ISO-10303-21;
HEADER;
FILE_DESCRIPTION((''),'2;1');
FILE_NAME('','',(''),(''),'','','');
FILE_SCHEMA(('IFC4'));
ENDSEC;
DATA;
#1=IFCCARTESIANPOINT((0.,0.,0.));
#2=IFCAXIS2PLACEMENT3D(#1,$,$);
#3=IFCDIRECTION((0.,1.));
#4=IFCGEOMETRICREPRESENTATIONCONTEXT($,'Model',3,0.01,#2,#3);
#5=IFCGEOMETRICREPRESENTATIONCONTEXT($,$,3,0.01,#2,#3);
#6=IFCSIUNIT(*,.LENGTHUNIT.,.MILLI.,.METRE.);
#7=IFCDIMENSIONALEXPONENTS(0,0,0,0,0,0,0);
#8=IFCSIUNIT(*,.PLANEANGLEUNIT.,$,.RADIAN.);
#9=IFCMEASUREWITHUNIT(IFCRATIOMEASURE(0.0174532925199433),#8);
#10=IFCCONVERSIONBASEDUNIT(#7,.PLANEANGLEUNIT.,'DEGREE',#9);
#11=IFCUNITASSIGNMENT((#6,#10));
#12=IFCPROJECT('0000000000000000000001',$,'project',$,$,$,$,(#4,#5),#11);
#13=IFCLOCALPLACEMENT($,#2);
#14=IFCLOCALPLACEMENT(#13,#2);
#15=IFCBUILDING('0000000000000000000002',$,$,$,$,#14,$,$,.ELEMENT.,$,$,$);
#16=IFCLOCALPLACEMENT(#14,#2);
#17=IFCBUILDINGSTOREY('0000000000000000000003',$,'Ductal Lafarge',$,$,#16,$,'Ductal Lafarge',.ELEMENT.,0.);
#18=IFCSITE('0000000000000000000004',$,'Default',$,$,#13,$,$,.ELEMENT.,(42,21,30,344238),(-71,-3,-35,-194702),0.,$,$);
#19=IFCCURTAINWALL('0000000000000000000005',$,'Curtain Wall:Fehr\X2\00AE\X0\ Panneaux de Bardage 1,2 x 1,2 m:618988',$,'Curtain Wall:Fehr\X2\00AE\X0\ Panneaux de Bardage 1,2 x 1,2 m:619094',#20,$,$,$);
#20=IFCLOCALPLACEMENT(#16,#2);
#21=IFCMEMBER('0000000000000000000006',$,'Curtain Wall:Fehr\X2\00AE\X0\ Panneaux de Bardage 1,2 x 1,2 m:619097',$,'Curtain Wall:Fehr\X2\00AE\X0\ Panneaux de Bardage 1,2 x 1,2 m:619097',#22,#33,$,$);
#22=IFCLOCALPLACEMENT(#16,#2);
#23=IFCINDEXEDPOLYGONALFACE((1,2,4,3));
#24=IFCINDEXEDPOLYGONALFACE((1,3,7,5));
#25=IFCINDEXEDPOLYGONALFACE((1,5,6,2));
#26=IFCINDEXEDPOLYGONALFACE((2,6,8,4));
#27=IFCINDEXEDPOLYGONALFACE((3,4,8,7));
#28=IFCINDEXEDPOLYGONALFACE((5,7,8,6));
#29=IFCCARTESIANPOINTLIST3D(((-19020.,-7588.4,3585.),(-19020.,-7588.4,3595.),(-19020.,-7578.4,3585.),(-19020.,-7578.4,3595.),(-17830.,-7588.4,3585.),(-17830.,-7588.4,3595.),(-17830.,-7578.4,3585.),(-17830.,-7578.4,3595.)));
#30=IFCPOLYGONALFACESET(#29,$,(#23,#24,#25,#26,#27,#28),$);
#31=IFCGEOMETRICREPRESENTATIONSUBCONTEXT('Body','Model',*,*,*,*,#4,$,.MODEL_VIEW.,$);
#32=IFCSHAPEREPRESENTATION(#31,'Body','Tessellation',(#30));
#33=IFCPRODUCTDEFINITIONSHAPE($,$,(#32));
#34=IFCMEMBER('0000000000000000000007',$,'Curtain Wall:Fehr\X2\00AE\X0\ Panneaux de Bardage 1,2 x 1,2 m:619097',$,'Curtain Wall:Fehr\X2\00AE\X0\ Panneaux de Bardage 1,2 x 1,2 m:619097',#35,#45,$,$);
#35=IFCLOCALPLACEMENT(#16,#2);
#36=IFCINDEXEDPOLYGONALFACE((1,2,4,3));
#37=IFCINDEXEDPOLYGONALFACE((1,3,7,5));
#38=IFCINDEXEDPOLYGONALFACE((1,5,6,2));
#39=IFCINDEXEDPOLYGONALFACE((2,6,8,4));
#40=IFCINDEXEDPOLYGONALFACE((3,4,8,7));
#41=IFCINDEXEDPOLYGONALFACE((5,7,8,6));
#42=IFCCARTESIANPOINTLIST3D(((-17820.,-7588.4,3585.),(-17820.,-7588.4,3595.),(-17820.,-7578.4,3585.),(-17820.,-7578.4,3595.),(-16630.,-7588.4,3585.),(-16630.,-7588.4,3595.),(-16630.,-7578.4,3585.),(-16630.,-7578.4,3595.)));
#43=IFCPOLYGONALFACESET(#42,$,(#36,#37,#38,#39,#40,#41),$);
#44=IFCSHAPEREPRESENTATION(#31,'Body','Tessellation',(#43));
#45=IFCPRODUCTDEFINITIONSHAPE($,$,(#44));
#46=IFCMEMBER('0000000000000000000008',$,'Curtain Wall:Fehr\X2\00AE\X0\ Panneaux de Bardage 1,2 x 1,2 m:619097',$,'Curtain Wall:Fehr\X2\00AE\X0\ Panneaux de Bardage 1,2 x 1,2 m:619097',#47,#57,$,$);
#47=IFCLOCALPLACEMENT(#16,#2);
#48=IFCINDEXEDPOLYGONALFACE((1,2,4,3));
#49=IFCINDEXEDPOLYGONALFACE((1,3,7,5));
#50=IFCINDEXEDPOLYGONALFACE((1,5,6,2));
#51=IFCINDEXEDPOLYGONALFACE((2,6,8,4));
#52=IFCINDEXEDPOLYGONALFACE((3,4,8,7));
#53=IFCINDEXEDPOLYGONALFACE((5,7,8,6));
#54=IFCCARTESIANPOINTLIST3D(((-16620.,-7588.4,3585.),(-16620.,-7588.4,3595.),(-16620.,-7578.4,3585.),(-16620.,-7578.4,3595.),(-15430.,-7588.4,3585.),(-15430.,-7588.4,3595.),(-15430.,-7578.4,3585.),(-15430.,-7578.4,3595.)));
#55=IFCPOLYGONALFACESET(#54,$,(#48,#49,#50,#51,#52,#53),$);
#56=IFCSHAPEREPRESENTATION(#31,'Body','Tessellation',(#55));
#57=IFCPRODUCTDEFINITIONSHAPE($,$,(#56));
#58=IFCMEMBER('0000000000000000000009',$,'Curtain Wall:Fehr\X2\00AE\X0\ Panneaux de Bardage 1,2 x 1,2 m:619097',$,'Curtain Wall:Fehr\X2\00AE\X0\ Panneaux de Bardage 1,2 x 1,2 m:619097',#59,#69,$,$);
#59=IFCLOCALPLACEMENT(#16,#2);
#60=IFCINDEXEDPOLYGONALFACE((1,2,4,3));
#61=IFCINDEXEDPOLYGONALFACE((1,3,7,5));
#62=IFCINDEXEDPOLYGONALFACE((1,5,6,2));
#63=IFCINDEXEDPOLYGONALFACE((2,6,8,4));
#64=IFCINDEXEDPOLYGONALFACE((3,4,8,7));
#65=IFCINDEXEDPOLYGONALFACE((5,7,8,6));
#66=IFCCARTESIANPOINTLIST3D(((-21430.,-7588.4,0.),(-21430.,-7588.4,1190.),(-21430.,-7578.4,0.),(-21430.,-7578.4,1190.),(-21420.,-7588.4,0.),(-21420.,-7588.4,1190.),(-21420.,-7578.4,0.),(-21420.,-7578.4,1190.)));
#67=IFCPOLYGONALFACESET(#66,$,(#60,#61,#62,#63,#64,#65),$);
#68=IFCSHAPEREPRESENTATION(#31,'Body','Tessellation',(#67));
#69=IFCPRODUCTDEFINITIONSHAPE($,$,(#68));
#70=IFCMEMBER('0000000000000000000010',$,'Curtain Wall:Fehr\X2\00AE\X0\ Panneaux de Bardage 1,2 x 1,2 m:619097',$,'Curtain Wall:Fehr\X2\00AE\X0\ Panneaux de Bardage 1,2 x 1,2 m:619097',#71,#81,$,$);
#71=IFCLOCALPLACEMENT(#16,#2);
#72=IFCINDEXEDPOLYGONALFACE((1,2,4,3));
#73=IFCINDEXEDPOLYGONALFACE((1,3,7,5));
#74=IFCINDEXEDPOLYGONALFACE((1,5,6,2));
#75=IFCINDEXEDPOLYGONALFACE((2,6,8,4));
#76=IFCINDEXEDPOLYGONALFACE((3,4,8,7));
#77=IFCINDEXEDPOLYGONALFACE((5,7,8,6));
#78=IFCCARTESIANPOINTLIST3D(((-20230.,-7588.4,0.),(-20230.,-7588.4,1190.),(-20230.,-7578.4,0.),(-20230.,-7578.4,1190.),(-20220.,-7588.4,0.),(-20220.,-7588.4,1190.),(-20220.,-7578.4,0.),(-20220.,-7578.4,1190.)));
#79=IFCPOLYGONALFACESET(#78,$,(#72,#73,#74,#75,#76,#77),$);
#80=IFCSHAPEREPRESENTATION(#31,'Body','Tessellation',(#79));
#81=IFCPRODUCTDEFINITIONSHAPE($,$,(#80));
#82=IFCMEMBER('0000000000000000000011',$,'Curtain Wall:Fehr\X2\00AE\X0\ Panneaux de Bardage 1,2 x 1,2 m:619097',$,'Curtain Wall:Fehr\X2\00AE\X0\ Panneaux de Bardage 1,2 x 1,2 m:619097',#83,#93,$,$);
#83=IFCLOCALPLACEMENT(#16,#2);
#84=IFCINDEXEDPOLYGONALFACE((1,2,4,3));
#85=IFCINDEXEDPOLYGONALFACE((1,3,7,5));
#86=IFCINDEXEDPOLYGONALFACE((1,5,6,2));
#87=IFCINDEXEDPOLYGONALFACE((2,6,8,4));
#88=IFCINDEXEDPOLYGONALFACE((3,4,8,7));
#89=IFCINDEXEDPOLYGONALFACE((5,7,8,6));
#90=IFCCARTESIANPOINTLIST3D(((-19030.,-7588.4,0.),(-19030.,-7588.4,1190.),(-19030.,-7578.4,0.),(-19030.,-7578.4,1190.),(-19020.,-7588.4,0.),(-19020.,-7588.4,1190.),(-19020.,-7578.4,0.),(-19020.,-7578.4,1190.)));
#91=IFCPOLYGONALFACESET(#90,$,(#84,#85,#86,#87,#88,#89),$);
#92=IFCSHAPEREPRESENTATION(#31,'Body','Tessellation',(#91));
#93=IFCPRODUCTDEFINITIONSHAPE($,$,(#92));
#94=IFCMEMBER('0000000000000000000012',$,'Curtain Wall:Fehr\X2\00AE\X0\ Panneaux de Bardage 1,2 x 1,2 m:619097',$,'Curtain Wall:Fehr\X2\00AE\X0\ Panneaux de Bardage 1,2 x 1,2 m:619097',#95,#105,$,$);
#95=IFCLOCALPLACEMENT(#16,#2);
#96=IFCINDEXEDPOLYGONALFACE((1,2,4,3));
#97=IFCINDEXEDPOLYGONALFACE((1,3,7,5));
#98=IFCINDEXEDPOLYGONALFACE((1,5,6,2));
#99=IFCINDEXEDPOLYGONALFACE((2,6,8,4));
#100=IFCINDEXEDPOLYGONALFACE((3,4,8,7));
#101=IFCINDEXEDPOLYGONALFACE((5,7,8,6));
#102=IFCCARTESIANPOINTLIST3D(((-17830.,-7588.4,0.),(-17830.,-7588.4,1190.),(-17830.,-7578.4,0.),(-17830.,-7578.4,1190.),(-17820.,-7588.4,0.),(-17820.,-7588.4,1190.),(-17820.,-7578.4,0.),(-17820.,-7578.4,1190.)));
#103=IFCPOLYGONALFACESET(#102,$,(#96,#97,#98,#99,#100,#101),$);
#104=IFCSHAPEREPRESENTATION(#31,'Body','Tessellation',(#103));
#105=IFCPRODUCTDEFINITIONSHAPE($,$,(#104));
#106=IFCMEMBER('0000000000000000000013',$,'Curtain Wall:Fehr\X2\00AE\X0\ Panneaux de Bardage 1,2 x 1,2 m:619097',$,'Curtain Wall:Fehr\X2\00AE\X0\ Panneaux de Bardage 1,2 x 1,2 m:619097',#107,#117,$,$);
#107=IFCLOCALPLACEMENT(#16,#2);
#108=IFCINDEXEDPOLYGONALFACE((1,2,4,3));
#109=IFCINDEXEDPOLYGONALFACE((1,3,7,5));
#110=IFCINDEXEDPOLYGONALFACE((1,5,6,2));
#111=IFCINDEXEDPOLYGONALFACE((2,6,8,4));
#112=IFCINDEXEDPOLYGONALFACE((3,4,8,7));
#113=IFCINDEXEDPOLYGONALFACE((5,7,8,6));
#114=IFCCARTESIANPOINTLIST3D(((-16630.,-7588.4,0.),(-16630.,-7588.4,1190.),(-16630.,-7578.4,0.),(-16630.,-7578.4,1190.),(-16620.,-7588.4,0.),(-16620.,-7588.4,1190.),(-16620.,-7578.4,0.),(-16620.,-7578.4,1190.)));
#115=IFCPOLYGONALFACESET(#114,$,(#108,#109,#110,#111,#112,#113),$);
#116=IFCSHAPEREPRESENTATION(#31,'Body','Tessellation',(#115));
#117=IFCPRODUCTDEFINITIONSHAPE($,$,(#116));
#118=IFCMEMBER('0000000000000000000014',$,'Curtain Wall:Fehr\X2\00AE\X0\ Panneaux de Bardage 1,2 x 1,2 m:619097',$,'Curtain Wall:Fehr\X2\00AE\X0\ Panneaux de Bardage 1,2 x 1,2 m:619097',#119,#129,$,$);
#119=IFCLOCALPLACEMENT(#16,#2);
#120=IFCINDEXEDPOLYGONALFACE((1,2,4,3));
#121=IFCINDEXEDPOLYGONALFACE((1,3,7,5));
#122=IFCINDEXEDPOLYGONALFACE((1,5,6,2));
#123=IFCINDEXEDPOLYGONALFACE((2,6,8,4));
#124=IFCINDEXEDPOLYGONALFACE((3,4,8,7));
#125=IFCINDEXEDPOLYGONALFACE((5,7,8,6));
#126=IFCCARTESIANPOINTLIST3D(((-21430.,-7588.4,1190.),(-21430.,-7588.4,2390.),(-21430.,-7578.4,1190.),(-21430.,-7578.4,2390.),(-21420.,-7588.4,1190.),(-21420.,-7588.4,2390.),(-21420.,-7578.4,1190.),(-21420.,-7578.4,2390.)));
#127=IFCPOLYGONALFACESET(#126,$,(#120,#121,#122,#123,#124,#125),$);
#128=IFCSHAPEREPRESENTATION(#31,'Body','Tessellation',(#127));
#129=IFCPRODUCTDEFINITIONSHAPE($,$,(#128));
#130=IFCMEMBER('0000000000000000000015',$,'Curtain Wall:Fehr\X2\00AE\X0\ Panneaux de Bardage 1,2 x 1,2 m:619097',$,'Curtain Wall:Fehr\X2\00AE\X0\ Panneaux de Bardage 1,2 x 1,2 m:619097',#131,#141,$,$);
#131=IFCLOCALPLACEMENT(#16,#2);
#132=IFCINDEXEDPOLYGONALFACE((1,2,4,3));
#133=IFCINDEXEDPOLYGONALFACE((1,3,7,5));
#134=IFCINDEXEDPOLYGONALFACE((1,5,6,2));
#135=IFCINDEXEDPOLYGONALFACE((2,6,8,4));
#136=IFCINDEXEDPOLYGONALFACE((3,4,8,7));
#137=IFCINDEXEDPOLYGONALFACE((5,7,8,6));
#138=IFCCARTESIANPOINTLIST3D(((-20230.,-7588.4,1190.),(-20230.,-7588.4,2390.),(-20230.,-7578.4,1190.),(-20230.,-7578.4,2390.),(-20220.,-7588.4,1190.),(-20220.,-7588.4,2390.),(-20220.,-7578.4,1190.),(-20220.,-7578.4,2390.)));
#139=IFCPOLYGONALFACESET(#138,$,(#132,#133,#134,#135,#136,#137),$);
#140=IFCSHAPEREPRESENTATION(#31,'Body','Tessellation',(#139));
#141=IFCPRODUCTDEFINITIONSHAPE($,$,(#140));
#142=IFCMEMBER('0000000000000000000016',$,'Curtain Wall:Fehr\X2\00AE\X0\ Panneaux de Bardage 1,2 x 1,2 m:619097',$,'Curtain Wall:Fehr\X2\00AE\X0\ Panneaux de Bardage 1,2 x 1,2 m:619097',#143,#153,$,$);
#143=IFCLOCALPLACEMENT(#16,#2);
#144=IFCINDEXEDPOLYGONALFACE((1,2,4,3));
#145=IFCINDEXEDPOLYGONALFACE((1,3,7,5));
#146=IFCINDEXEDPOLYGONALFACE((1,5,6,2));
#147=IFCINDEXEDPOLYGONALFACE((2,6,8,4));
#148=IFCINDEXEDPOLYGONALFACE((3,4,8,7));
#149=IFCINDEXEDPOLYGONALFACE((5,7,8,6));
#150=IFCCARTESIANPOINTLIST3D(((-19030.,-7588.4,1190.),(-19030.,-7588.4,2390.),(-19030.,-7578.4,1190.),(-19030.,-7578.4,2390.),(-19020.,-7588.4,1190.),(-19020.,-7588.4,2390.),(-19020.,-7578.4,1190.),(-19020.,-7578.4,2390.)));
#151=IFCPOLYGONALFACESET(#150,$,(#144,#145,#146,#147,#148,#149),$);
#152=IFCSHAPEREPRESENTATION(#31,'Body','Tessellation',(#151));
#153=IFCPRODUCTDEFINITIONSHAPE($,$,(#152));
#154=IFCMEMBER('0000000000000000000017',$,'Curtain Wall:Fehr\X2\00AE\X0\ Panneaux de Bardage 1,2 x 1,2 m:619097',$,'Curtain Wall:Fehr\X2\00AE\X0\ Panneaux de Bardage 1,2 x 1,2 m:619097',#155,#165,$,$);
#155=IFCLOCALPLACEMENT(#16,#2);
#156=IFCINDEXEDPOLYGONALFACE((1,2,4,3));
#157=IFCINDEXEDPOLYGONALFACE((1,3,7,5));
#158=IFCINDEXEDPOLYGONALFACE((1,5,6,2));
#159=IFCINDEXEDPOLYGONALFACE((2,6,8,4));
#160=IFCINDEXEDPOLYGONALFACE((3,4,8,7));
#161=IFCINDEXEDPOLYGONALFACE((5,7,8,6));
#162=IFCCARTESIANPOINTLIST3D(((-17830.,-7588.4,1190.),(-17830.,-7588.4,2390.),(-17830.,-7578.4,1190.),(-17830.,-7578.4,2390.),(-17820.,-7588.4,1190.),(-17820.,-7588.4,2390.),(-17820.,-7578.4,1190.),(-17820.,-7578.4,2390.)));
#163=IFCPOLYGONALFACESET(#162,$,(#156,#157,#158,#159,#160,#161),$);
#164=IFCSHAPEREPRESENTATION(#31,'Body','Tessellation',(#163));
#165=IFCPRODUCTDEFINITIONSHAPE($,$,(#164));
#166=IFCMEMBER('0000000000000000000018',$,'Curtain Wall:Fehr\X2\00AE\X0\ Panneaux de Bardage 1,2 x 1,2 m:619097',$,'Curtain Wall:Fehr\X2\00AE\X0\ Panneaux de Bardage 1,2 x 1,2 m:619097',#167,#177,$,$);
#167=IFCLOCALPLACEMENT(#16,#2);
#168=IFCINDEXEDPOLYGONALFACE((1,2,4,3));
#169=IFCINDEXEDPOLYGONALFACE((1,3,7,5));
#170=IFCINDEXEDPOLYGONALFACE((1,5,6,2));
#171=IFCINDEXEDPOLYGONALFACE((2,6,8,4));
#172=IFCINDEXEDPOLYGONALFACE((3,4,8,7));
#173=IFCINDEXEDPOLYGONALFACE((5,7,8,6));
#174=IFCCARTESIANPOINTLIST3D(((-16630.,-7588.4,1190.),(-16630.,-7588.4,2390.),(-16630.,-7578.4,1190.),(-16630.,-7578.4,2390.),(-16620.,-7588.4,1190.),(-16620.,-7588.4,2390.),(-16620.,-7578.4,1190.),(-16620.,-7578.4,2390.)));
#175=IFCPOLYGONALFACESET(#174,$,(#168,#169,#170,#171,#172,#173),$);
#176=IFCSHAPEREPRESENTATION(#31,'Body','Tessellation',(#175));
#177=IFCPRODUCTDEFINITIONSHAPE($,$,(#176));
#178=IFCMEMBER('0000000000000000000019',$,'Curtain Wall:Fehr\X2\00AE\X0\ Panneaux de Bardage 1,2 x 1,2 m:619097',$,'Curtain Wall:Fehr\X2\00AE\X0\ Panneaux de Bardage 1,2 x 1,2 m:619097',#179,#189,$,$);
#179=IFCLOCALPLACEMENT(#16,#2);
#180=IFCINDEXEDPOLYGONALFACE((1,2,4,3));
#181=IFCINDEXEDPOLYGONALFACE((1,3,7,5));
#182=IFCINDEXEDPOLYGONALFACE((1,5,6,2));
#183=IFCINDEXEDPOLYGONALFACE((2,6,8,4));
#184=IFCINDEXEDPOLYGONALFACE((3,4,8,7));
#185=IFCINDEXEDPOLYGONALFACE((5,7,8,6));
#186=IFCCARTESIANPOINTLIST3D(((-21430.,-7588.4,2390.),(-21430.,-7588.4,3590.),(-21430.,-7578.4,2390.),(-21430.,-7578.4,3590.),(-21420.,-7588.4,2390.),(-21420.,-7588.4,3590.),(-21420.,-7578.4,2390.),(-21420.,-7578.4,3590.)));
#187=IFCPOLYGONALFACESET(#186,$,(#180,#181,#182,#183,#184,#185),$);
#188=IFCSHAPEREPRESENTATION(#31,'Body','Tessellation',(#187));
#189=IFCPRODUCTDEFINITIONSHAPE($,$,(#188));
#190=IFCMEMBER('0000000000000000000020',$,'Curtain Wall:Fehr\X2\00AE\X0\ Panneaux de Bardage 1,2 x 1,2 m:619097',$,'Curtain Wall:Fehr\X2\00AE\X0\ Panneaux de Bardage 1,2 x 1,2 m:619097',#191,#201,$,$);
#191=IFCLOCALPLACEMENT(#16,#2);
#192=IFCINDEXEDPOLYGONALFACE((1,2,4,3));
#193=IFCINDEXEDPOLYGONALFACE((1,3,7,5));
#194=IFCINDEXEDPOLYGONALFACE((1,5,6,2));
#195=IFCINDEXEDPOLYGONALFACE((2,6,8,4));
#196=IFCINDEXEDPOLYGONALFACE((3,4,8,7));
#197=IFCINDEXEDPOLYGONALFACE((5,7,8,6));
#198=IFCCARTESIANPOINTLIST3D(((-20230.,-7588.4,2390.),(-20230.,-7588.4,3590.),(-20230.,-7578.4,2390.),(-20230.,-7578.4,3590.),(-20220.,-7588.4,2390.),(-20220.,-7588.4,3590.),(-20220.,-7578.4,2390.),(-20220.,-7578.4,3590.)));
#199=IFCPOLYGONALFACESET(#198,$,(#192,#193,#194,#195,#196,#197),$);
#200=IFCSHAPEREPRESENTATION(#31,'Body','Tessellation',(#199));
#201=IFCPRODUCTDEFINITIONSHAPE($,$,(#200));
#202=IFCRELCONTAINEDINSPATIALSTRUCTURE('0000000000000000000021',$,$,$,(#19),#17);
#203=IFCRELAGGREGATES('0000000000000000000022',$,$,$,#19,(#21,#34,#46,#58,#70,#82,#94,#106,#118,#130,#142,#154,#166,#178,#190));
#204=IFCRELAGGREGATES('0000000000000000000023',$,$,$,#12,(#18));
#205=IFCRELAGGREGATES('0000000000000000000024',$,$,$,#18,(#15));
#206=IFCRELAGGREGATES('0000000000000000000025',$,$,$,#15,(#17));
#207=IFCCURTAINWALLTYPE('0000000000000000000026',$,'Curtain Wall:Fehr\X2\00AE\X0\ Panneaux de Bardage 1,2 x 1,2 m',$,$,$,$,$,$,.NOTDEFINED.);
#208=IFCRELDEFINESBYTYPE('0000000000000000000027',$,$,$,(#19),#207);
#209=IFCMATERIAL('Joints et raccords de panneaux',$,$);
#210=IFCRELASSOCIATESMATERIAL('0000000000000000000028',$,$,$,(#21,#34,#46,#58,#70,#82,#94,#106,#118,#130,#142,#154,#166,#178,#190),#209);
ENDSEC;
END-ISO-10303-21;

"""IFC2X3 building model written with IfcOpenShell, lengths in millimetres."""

from ifc_helpers import new_model, entity, si_unit, converted_unit, direction, frame, frame_2d, origin, origin_2d_with_axis, place, context, subcontext, project, spatial, rectangle, extrude, material, type_object, element, aggregate, save


model = new_model("IFC2X3")

# Units and contexts
model_context = context("Model", 3, precision=0.01, world=origin(), true_north=direction((0.0, 1.0)))
context_of_model = context(None, 3, precision=0.01, world=origin(), true_north=direction((0.0, 1.0)))
body_context = subcontext(model_context, "Body", "Model", "MODEL_VIEW")
ifc_project = project(units=[si_unit("LENGTHUNIT", "METRE", prefix="MILLI"), converted_unit("PLANEANGLEUNIT", "DEGREE", entity("IfcRatioMeasure", 0.0174532925199433), si_unit("PLANEANGLEUNIT", "RADIAN"), dimensions=[0, 0, 0, 0, 0, 0, 0])], contexts=[model_context, context_of_model])

# Site, building, storey
site_placement = place(None, origin())
site = spatial("IfcSite", under=ifc_project, at=site_placement, Name="Default", CompositionType="ELEMENT", RefLatitude=(42, 21, 30, 344238), RefLongitude=(-71, -3, -35, -194702), RefElevation=0.0)
building_placement = place(site_placement, origin())
building = spatial("IfcBuilding", under=site, at=building_placement, CompositionType="ELEMENT")
storey_placement = place(building_placement, origin())
storey = spatial("IfcBuildingStorey", under=building, at=storey_placement, Name="Ductal Lafarge", LongName="Ductal Lafarge", CompositionType="ELEMENT", Elevation=0.0)

# Curtain wall, members
curtain_wall_type = type_object("IfcCurtainWallType", Name="Curtain Wall:Fehr® Panneaux de Bardage 1,2 x 1,2 m", PredefinedType="NOTDEFINED")
curtain_wall_placement = place(storey_placement, origin())
curtain_wall = element("IfcCurtainWall", 1, at=curtain_wall_placement, inside=storey, type_object=curtain_wall_type, Name="Curtain Wall:Fehr® Panneaux de Bardage 1,2 x 1,2 m:618988", ObjectType="Curtain Wall:Fehr® Panneaux de Bardage 1,2 x 1,2 m:619094")
ifc_material = material(Name="Joints et raccords de panneaux")
member_1_placement = place(curtain_wall_placement, frame((-19020.0, -7588.4, 3585.0)))
member_1 = element("IfcMember", 2, at=member_1_placement, material=ifc_material, Name="Curtain Wall:Fehr® Panneaux de Bardage 1,2 x 1,2 m:619097", ObjectType="Curtain Wall:Fehr® Panneaux de Bardage 1,2 x 1,2 m:619097", context=body_context, shape_type="SweptSolid", body=[
    extrude(rectangle(XDim=1190.0, YDim=10.0, at=frame_2d((0.0, 0.0), x_axis=(1.0, 0.0))), frame((595.0, 5.0, 0.0), z_axis=(0.0, 0.0, 1.0), x_axis=(-1.0, 0.0, 0.0)), (0.0, 0.0, 1.0), 10.0),
])
member_2_placement = place(curtain_wall_placement, frame((-17820.0, -7588.4, 3585.0)))
member_2 = element("IfcMember", 3, at=member_2_placement, material=ifc_material, Name="Curtain Wall:Fehr® Panneaux de Bardage 1,2 x 1,2 m:619097", ObjectType="Curtain Wall:Fehr® Panneaux de Bardage 1,2 x 1,2 m:619097", context=body_context, shape_type="SweptSolid", body=[
    extrude(rectangle(XDim=1190.0, YDim=10.0, at=frame_2d((0.0, 0.0), x_axis=(1.0, 0.0))), frame((595.0, 5.0, 0.0), z_axis=(0.0, 0.0, 1.0), x_axis=(-1.0, 0.0, 0.0)), (0.0, 0.0, 1.0), 10.0),
])
member_3_placement = place(curtain_wall_placement, frame((-16620.0, -7588.4, 3585.0)))
member_3 = element("IfcMember", 4, at=member_3_placement, material=ifc_material, Name="Curtain Wall:Fehr® Panneaux de Bardage 1,2 x 1,2 m:619097", ObjectType="Curtain Wall:Fehr® Panneaux de Bardage 1,2 x 1,2 m:619097", context=body_context, shape_type="SweptSolid", body=[
    extrude(rectangle(XDim=1190.0, YDim=10.0, at=frame_2d((0.0, 0.0), x_axis=(1.0, 0.0))), frame((595.0, 5.0, 0.0), z_axis=(0.0, 0.0, 1.0), x_axis=(-1.0, 0.0, 0.0)), (0.0, 0.0, 1.0), 10.0),
])
member_4_placement = place(curtain_wall_placement, frame((-21430.0, -7588.4, 0.0)))
member_4 = element("IfcMember", 5, at=member_4_placement, material=ifc_material, Name="Curtain Wall:Fehr® Panneaux de Bardage 1,2 x 1,2 m:619097", ObjectType="Curtain Wall:Fehr® Panneaux de Bardage 1,2 x 1,2 m:619097", context=body_context, shape_type="SweptSolid", body=[
    extrude(rectangle(XDim=10.0, YDim=10.0, at=origin_2d_with_axis()), frame((5.0, 5.0, 0.0), z_axis=(0.0, 0.0, 1.0), x_axis=(0.0, 1.0, 0.0)), (0.0, 0.0, 1.0), 1190.0),
])
member_5_placement = place(curtain_wall_placement, frame((-20230.0, -7588.4, 0.0)))
member_5 = element("IfcMember", 6, at=member_5_placement, material=ifc_material, Name="Curtain Wall:Fehr® Panneaux de Bardage 1,2 x 1,2 m:619097", ObjectType="Curtain Wall:Fehr® Panneaux de Bardage 1,2 x 1,2 m:619097", context=body_context, shape_type="SweptSolid", body=[
    extrude(rectangle(XDim=10.0, YDim=10.0, at=origin_2d_with_axis()), frame((5.0, 5.0, 0.0), z_axis=(0.0, 0.0, 1.0), x_axis=(0.0, 1.0, 0.0)), (0.0, 0.0, 1.0), 1190.0),
])
member_6_placement = place(curtain_wall_placement, frame((-19030.0, -7588.4, 0.0)))
member_6 = element("IfcMember", 7, at=member_6_placement, material=ifc_material, Name="Curtain Wall:Fehr® Panneaux de Bardage 1,2 x 1,2 m:619097", ObjectType="Curtain Wall:Fehr® Panneaux de Bardage 1,2 x 1,2 m:619097", context=body_context, shape_type="SweptSolid", body=[
    extrude(rectangle(XDim=10.0, YDim=10.0, at=origin_2d_with_axis()), frame((5.0, 5.0, 0.0), z_axis=(0.0, 0.0, 1.0), x_axis=(0.0, 1.0, 0.0)), (0.0, 0.0, 1.0), 1190.0),
])
member_7_placement = place(curtain_wall_placement, frame((-17830.0, -7588.4, 0.0)))
member_7 = element("IfcMember", 8, at=member_7_placement, material=ifc_material, Name="Curtain Wall:Fehr® Panneaux de Bardage 1,2 x 1,2 m:619097", ObjectType="Curtain Wall:Fehr® Panneaux de Bardage 1,2 x 1,2 m:619097", context=body_context, shape_type="SweptSolid", body=[
    extrude(rectangle(XDim=10.0, YDim=10.0, at=origin_2d_with_axis()), frame((5.0, 5.0, 0.0), z_axis=(0.0, 0.0, 1.0), x_axis=(0.0, 1.0, 0.0)), (0.0, 0.0, 1.0), 1190.0),
])
member_8_placement = place(curtain_wall_placement, frame((-16630.0, -7588.4, 0.0)))
member_8 = element("IfcMember", 9, at=member_8_placement, material=ifc_material, Name="Curtain Wall:Fehr® Panneaux de Bardage 1,2 x 1,2 m:619097", ObjectType="Curtain Wall:Fehr® Panneaux de Bardage 1,2 x 1,2 m:619097", context=body_context, shape_type="SweptSolid", body=[
    extrude(rectangle(XDim=10.0, YDim=10.0, at=origin_2d_with_axis()), frame((5.0, 5.0, 0.0), z_axis=(0.0, 0.0, 1.0), x_axis=(0.0, 1.0, 0.0)), (0.0, 0.0, 1.0), 1190.0),
])
member_9_placement = place(curtain_wall_placement, frame((-21430.0, -7588.4, 1190.0)))
member_9 = element("IfcMember", 10, at=member_9_placement, material=ifc_material, Name="Curtain Wall:Fehr® Panneaux de Bardage 1,2 x 1,2 m:619097", ObjectType="Curtain Wall:Fehr® Panneaux de Bardage 1,2 x 1,2 m:619097", context=body_context, shape_type="SweptSolid", body=[
    extrude(rectangle(XDim=10.0, YDim=10.0, at=origin_2d_with_axis()), frame((5.0, 5.0, 0.0), z_axis=(0.0, 0.0, 1.0), x_axis=(0.0, 1.0, 0.0)), (0.0, 0.0, 1.0), 1200.0),
])
member_10_placement = place(curtain_wall_placement, frame((-20230.0, -7588.4, 1190.0)))
member_10 = element("IfcMember", 11, at=member_10_placement, material=ifc_material, Name="Curtain Wall:Fehr® Panneaux de Bardage 1,2 x 1,2 m:619097", ObjectType="Curtain Wall:Fehr® Panneaux de Bardage 1,2 x 1,2 m:619097", context=body_context, shape_type="SweptSolid", body=[
    extrude(rectangle(XDim=10.0, YDim=10.0, at=origin_2d_with_axis()), frame((5.0, 5.0, 0.0), z_axis=(0.0, 0.0, 1.0), x_axis=(0.0, 1.0, 0.0)), (0.0, 0.0, 1.0), 1200.0),
])
member_11_placement = place(curtain_wall_placement, frame((-19030.0, -7588.4, 1190.0)))
member_11 = element("IfcMember", 12, at=member_11_placement, material=ifc_material, Name="Curtain Wall:Fehr® Panneaux de Bardage 1,2 x 1,2 m:619097", ObjectType="Curtain Wall:Fehr® Panneaux de Bardage 1,2 x 1,2 m:619097", context=body_context, shape_type="SweptSolid", body=[
    extrude(rectangle(XDim=10.0, YDim=10.0, at=origin_2d_with_axis()), frame((5.0, 5.0, 0.0), z_axis=(0.0, 0.0, 1.0), x_axis=(0.0, 1.0, 0.0)), (0.0, 0.0, 1.0), 1200.0),
])
member_12_placement = place(curtain_wall_placement, frame((-17830.0, -7588.4, 1190.0)))
member_12 = element("IfcMember", 13, at=member_12_placement, material=ifc_material, Name="Curtain Wall:Fehr® Panneaux de Bardage 1,2 x 1,2 m:619097", ObjectType="Curtain Wall:Fehr® Panneaux de Bardage 1,2 x 1,2 m:619097", context=body_context, shape_type="SweptSolid", body=[
    extrude(rectangle(XDim=10.0, YDim=10.0, at=origin_2d_with_axis()), frame((5.0, 5.0, 0.0), z_axis=(0.0, 0.0, 1.0), x_axis=(0.0, 1.0, 0.0)), (0.0, 0.0, 1.0), 1200.0),
])
member_13_placement = place(curtain_wall_placement, frame((-16630.0, -7588.4, 1190.0)))
member_13 = element("IfcMember", 14, at=member_13_placement, material=ifc_material, Name="Curtain Wall:Fehr® Panneaux de Bardage 1,2 x 1,2 m:619097", ObjectType="Curtain Wall:Fehr® Panneaux de Bardage 1,2 x 1,2 m:619097", context=body_context, shape_type="SweptSolid", body=[
    extrude(rectangle(XDim=10.0, YDim=10.0, at=origin_2d_with_axis()), frame((5.0, 5.0, 0.0), z_axis=(0.0, 0.0, 1.0), x_axis=(0.0, 1.0, 0.0)), (0.0, 0.0, 1.0), 1200.0),
])
member_14_placement = place(curtain_wall_placement, frame((-21430.0, -7588.4, 2390.0)))
member_14 = element("IfcMember", 15, at=member_14_placement, material=ifc_material, Name="Curtain Wall:Fehr® Panneaux de Bardage 1,2 x 1,2 m:619097", ObjectType="Curtain Wall:Fehr® Panneaux de Bardage 1,2 x 1,2 m:619097", context=body_context, shape_type="SweptSolid", body=[
    extrude(rectangle(XDim=10.0, YDim=10.0, at=origin_2d_with_axis()), frame((5.0, 5.0, 0.0), z_axis=(0.0, 0.0, 1.0), x_axis=(0.0, 1.0, 0.0)), (0.0, 0.0, 1.0), 1200.0),
])
member_15_placement = place(curtain_wall_placement, frame((-20230.0, -7588.4, 2390.0)))
member_15 = element("IfcMember", 16, at=member_15_placement, material=ifc_material, Name="Curtain Wall:Fehr® Panneaux de Bardage 1,2 x 1,2 m:619097", ObjectType="Curtain Wall:Fehr® Panneaux de Bardage 1,2 x 1,2 m:619097", context=body_context, shape_type="SweptSolid", body=[
    extrude(rectangle(XDim=10.0, YDim=10.0, at=origin_2d_with_axis()), frame((5.0, 5.0, 0.0), z_axis=(0.0, 0.0, 1.0), x_axis=(0.0, 1.0, 0.0)), (0.0, 0.0, 1.0), 1200.0),
])
aggregate(curtain_wall, [member_1, member_2, member_3, member_4, member_5, member_6, member_7, member_8, member_9, member_10, member_11, member_12, member_13, member_14, member_15])

save(model, "model.ifc")
